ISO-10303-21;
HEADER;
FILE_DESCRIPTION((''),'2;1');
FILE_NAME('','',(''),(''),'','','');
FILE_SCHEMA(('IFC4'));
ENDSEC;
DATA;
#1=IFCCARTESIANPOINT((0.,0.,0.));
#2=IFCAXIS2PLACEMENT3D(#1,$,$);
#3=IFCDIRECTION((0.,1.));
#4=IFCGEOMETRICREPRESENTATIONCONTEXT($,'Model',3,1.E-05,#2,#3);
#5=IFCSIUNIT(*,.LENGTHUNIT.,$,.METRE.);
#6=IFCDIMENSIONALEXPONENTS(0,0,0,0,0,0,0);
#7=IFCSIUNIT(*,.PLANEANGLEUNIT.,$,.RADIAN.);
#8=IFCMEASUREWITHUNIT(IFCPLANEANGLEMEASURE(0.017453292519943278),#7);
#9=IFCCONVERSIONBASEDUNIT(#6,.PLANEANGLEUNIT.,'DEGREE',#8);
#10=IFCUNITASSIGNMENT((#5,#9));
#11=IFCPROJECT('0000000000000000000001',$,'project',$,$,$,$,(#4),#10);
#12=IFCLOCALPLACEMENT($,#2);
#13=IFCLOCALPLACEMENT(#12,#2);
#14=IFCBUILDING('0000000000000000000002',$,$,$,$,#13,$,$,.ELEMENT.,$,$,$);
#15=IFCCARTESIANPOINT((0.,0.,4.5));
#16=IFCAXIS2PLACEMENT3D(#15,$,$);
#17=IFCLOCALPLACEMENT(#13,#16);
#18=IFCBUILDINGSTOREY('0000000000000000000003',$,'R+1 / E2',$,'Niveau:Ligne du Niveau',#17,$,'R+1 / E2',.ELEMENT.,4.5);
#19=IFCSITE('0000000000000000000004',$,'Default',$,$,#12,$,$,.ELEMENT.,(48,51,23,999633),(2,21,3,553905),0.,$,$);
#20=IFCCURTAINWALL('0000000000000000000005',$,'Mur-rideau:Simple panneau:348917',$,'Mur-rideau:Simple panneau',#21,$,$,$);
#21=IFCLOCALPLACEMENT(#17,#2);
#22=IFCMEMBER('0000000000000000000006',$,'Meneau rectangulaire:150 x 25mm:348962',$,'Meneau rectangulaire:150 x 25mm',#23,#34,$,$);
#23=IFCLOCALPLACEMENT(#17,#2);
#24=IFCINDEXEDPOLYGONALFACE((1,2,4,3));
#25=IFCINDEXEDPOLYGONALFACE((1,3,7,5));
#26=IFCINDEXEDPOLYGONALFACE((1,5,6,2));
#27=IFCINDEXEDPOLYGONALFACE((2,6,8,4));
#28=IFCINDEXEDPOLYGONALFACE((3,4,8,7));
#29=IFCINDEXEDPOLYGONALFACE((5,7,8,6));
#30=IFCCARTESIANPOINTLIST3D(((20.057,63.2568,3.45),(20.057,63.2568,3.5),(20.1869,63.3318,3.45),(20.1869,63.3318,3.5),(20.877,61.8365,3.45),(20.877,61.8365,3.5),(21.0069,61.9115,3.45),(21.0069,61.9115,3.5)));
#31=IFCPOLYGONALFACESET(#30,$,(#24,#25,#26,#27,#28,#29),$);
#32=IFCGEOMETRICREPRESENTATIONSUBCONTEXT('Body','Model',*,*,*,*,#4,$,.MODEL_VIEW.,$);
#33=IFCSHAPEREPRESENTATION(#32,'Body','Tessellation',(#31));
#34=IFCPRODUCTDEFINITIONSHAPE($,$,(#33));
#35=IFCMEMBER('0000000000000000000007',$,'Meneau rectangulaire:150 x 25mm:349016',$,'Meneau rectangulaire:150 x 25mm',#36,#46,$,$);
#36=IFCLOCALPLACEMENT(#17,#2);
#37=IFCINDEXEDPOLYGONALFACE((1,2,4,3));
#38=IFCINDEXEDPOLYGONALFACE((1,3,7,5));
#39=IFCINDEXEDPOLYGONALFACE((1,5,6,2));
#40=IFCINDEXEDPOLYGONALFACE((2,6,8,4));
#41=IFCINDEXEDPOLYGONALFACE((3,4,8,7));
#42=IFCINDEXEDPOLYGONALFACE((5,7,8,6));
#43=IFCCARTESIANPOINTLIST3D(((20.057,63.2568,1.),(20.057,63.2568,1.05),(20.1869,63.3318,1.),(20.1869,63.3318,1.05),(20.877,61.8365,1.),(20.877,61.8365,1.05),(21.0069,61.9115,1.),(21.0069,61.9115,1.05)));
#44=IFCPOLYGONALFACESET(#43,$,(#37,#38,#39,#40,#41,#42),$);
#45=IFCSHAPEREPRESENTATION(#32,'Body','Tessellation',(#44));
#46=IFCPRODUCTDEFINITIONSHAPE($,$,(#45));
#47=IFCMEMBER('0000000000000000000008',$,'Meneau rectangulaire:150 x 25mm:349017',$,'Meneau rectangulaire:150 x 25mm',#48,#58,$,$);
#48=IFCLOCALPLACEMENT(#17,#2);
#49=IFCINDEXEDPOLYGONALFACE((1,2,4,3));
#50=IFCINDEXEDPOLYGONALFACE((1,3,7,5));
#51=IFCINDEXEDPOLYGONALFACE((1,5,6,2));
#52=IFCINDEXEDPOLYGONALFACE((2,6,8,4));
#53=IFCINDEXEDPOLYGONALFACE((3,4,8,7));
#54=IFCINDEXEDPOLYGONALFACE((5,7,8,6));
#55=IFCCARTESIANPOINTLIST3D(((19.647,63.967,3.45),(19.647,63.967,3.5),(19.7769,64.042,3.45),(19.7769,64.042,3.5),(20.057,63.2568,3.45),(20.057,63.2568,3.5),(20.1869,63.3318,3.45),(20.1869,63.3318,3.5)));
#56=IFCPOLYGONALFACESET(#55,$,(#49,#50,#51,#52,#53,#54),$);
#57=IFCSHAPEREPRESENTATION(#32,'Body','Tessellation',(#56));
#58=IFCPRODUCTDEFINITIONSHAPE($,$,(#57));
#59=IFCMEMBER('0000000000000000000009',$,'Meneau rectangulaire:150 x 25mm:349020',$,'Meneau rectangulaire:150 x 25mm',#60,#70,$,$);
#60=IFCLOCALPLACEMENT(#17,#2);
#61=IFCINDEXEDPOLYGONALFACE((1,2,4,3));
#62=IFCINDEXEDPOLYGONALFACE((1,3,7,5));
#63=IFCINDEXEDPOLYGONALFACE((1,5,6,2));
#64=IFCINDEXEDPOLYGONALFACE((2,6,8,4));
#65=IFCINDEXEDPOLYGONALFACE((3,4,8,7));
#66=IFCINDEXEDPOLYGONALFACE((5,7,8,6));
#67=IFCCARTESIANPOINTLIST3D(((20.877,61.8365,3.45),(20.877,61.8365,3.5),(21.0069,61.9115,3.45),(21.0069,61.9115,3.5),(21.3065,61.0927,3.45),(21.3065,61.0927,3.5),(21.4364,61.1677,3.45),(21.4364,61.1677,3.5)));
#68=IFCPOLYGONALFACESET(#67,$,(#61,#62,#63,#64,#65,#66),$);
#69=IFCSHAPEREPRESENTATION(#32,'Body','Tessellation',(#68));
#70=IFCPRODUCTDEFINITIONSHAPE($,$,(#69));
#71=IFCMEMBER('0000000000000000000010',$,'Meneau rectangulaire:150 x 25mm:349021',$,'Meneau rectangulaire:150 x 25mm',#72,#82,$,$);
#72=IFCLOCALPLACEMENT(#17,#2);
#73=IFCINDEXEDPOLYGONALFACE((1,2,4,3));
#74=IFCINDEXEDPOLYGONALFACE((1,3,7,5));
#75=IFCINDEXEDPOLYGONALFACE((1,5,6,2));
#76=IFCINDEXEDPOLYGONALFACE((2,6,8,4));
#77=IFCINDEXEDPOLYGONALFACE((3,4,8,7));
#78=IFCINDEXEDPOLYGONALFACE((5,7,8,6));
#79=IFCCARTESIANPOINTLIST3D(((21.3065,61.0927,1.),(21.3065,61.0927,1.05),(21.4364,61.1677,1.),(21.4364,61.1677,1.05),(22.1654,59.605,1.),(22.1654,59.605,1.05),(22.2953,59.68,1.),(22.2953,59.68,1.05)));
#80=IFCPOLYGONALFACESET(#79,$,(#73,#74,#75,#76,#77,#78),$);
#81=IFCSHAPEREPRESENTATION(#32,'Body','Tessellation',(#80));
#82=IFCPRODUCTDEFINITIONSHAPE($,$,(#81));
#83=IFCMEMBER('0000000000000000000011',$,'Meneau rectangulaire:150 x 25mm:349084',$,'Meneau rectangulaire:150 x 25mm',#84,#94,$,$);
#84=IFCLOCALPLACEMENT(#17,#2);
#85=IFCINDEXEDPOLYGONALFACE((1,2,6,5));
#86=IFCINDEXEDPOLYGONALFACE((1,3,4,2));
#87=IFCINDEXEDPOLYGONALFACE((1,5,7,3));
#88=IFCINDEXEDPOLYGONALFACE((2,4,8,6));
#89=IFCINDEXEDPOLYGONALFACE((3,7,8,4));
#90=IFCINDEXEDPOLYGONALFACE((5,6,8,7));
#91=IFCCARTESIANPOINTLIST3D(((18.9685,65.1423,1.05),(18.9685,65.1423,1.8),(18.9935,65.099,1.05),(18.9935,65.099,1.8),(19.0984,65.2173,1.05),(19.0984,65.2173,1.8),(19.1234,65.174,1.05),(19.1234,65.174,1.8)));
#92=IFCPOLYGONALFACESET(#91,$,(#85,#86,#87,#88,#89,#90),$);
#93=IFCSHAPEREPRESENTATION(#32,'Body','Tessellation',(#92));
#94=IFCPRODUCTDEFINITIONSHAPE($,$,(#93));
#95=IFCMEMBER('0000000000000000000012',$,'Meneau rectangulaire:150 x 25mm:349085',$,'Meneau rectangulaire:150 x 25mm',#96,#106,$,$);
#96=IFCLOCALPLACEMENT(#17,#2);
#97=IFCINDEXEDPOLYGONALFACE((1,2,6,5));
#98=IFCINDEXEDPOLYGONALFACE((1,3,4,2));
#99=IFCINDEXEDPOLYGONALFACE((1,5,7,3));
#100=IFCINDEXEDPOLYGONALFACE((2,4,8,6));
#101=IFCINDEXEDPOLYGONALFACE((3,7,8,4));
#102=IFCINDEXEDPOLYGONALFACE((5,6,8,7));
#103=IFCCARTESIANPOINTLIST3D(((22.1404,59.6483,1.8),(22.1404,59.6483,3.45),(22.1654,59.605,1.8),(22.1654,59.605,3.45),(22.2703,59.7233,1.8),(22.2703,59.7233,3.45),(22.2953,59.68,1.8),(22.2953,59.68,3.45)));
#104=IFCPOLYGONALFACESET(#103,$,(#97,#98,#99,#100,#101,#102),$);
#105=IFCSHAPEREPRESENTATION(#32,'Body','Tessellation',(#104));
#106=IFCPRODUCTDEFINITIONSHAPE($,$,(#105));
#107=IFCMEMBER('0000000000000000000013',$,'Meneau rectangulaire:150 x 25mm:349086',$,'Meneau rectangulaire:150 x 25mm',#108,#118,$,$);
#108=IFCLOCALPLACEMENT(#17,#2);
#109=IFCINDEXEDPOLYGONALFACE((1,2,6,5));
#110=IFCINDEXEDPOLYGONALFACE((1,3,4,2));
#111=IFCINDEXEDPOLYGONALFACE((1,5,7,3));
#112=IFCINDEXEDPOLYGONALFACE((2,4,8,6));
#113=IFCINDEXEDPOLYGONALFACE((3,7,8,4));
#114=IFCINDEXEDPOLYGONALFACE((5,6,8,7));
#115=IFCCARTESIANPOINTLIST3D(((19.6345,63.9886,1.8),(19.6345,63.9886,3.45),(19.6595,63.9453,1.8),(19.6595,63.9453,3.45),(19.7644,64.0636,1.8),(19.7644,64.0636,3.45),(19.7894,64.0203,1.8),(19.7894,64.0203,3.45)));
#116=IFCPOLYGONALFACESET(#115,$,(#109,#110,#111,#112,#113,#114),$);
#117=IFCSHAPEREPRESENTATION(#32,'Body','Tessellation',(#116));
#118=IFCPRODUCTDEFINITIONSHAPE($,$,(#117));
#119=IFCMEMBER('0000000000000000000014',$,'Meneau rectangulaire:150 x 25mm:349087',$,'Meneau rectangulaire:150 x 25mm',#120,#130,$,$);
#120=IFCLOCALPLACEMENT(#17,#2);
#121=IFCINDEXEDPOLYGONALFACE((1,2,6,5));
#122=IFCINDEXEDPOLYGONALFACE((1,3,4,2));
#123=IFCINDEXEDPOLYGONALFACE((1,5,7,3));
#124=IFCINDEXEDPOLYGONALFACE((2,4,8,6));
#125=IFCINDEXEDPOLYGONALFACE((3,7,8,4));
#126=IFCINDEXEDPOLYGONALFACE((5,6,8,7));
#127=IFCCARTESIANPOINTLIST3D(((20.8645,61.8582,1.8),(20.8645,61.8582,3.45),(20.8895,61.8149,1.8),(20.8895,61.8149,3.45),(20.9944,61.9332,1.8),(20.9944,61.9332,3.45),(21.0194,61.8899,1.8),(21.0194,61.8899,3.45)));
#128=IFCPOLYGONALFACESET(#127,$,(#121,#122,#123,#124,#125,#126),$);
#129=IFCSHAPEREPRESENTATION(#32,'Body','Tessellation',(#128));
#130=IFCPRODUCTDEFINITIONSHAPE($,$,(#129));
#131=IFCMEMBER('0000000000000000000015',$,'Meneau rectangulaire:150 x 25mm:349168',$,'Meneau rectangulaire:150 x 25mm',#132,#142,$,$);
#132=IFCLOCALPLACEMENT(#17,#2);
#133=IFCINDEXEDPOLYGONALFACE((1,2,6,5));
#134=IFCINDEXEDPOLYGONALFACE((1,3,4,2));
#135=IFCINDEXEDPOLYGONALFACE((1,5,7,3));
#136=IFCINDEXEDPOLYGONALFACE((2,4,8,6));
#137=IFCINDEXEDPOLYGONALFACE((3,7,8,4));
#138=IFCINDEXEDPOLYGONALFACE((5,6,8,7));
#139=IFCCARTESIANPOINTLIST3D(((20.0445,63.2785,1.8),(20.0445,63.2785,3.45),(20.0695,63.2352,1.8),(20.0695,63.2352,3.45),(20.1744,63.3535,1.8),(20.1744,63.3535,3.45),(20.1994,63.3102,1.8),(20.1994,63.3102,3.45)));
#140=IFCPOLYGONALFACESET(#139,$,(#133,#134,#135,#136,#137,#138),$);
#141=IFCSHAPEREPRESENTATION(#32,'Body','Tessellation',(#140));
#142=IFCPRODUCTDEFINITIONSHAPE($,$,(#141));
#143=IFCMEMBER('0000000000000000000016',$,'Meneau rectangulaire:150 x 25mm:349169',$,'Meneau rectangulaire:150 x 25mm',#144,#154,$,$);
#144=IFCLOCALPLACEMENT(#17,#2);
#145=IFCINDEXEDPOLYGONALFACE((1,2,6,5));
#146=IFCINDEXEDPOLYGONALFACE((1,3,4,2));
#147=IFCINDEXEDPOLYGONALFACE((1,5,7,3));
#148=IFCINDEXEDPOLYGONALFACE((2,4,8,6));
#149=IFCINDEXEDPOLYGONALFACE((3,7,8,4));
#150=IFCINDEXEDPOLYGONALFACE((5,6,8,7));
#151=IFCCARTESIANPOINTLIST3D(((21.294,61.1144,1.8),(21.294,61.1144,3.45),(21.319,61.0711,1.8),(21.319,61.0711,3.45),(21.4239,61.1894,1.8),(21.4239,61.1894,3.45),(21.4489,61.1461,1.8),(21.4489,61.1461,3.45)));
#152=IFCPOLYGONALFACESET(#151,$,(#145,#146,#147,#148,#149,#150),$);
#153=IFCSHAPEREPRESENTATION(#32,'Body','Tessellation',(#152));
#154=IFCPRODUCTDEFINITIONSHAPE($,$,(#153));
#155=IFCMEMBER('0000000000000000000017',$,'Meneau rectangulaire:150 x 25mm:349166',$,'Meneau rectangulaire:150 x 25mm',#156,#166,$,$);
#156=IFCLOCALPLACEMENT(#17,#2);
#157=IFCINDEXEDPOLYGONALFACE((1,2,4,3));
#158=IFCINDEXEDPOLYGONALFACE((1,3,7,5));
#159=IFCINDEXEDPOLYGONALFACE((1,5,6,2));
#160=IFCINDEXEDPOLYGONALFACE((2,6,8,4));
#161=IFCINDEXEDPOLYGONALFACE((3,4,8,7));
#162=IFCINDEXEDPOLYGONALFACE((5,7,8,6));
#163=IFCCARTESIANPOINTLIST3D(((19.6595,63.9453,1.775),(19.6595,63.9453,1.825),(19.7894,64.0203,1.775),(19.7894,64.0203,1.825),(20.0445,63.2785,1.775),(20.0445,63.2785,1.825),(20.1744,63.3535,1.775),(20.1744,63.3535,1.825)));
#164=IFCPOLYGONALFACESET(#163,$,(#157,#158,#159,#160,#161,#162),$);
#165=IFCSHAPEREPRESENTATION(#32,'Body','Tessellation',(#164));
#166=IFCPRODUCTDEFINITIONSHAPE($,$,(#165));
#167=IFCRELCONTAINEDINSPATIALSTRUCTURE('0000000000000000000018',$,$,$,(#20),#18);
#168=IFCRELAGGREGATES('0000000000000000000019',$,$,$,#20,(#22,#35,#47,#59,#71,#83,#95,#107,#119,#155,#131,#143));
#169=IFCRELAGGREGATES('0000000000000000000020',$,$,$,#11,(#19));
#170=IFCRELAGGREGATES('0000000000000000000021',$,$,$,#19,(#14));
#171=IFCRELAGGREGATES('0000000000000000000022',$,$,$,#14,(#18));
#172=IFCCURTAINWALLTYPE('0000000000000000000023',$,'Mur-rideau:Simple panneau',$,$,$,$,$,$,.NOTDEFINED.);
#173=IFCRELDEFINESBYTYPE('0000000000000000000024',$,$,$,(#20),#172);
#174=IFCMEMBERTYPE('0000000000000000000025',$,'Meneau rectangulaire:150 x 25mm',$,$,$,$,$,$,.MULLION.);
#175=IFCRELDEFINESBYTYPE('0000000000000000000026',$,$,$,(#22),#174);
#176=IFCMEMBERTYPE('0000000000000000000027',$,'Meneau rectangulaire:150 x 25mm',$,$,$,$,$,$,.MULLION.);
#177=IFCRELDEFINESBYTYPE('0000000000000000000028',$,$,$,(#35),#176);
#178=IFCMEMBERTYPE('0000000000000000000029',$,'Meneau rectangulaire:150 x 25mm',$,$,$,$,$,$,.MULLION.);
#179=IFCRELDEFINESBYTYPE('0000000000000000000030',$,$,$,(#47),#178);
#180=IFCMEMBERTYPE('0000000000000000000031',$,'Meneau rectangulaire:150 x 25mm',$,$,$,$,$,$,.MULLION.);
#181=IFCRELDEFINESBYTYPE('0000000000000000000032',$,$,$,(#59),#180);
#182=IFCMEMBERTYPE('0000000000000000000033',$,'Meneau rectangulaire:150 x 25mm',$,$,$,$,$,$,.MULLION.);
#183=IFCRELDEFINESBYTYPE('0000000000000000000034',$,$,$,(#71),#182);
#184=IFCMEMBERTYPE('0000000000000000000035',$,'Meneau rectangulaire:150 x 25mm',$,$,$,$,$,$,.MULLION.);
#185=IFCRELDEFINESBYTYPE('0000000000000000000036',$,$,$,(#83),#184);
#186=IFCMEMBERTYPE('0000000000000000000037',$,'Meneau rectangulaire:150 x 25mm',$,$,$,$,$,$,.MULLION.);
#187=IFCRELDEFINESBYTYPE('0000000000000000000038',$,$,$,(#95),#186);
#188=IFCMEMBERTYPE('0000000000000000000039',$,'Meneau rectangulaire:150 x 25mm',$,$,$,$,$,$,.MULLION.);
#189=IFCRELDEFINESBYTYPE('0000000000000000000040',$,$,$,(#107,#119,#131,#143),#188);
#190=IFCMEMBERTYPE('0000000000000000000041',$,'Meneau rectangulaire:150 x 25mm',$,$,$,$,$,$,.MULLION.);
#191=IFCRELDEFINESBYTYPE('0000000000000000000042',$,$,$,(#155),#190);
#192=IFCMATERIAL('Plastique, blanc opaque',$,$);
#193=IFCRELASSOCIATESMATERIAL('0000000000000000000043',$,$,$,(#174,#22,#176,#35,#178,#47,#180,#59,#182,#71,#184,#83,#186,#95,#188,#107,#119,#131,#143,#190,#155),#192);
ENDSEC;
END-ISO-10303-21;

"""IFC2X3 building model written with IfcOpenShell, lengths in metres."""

from ifc_helpers import new_model, entity, si_unit, converted_unit, direction, frame, origin, origin_2d_with_axis, place, context, subcontext, project, spatial, rectangle, extrude, source, transform, mapped, material, type_object, type_shapes, element, aggregate, save


model = new_model("IFC2X3")

# Units and contexts
model_context = context("Model", 3, precision=1e-05, world=origin(), true_north=direction((0.0, 1.0)))
body_context = subcontext(model_context, "Body", "Model", "MODEL_VIEW")
ifc_project = project(units=[si_unit("LENGTHUNIT", "METRE"), converted_unit("PLANEANGLEUNIT", "DEGREE", entity("IfcPlaneAngleMeasure", 0.017453292519943278), si_unit("PLANEANGLEUNIT", "RADIAN"), dimensions=[0, 0, 0, 0, 0, 0, 0])], contexts=[model_context])

# Site, building, storey
site_placement = place(None, origin())
site = spatial("IfcSite", under=ifc_project, at=site_placement, Name="Default", CompositionType="ELEMENT", RefLatitude=(48, 51, 23, 999633), RefLongitude=(2, 21, 3, 553905), RefElevation=0.0)
building_placement = place(site_placement, origin())
building = spatial("IfcBuilding", under=site, at=building_placement, CompositionType="ELEMENT")
storey_placement = place(building_placement, frame((0.0, 0.0, 4.5)))
storey = spatial("IfcBuildingStorey", under=building, at=storey_placement, Name="R+1 / E2", ObjectType="Niveau:Ligne du Niveau", LongName="R+1 / E2", CompositionType="ELEMENT", Elevation=4.5)

# Curtain wall, members
curtain_wall_type = type_object("IfcCurtainWallType", Name="Mur-rideau:Simple panneau", PredefinedType="NOTDEFINED")
ifc_material_1 = material(Name="Plastique, blanc opaque")
curtain_wall_1_placement = place(storey_placement, frame((0.0, 0.0, -4.5)))
curtain_wall_1 = element("IfcCurtainWall", 1, at=curtain_wall_1_placement, inside=storey, type_object=curtain_wall_type, Name="Mur-rideau:Simple panneau:348917", ObjectType="Mur-rideau:Simple panneau")
member_type_1 = type_object("IfcMemberType", Name="Meneau rectangulaire:150 x 25mm", PredefinedType="MULLION", material=ifc_material_1)
shared_shape_1 = source(origin(), body_context, "Body", "SweptSolid", [
    extrude(rectangle(XDim=0.05, YDim=0.15, at=origin_2d_with_axis()), frame((-0.025, 0.0, -1.64), z_axis=(0.0, 0.0, 1.0), x_axis=(-1.0, 0.0, 0.0)), (0.0, 0.0, 1.0), 1.64),
])
type_shapes(member_type_1, [shared_shape_1])
member_1_placement = place(curtain_wall_1_placement, frame((20.942, 61.874, 8.0), z_axis=(0.5, -0.866025, 0.0), x_axis=(0.0, 0.0, 1.0)))
member_1 = element("IfcMember", 2, at=member_1_placement, type_object=member_type_1, material=ifc_material_1, Name="Meneau rectangulaire:150 x 25mm:348962", ObjectType="Meneau rectangulaire:150 x 25mm", context=body_context, shape_type="MappedRepresentation", body=[
    mapped(shared_shape_1, transform((0.0, 0.0, 0.0), scale=1.0)),
])
member_type_2 = type_object("IfcMemberType", Name="Meneau rectangulaire:150 x 25mm", PredefinedType="MULLION", material=ifc_material_1)
shared_shape_2 = source(origin(), body_context, "Body", "SweptSolid", [
    extrude(rectangle(XDim=0.05, YDim=0.15, at=origin_2d_with_axis()), frame((-0.025, 0.0, -1.64), z_axis=(0.0, 0.0, 1.0), x_axis=(-1.0, 0.0, 0.0)), (0.0, 0.0, 1.0), 1.64),
])
type_shapes(member_type_2, [shared_shape_2])
member_2_placement = place(curtain_wall_1_placement, frame((20.122, 63.2943, 5.5), z_axis=(-0.5, 0.866025, 0.0), x_axis=(0.0, 0.0, -1.0)))
member_2 = element("IfcMember", 3, at=member_2_placement, type_object=member_type_2, material=ifc_material_1, Name="Meneau rectangulaire:150 x 25mm:349016", ObjectType="Meneau rectangulaire:150 x 25mm", context=body_context, shape_type="MappedRepresentation", body=[
    mapped(shared_shape_2, transform((0.0, 0.0, 0.0), scale=1.0)),
])
member_type_3 = type_object("IfcMemberType", Name="Meneau rectangulaire:150 x 25mm", PredefinedType="MULLION", material=ifc_material_1)
shared_shape_3 = source(origin(), body_context, "Body", "SweptSolid", [
    extrude(rectangle(XDim=0.05, YDim=0.15, at=origin_2d_with_axis()), frame((-0.025, 0.0, -0.82), z_axis=(0.0, 0.0, 1.0), x_axis=(-1.0, 0.0, 0.0)), (0.0, 0.0, 1.0), 0.82),
])
type_shapes(member_type_3, [shared_shape_3])
member_3_placement = place(curtain_wall_1_placement, frame((20.122, 63.2943, 8.0), z_axis=(0.5, -0.866025, 0.0), x_axis=(0.0, 0.0, 1.0)))
member_3 = element("IfcMember", 4, at=member_3_placement, type_object=member_type_3, material=ifc_material_1, Name="Meneau rectangulaire:150 x 25mm:349017", ObjectType="Meneau rectangulaire:150 x 25mm", context=body_context, shape_type="MappedRepresentation", body=[
    mapped(shared_shape_3, transform((0.0, 0.0, 0.0), scale=1.0)),
])
member_type_4 = type_object("IfcMemberType", Name="Meneau rectangulaire:150 x 25mm", PredefinedType="MULLION", material=ifc_material_1)
shared_shape_4 = source(origin(), body_context, "Body", "SweptSolid", [
    extrude(rectangle(XDim=0.05, YDim=0.15, at=origin_2d_with_axis()), frame((-0.025, 0.0, -0.8589), z_axis=(0.0, 0.0, 1.0), x_axis=(-1.0, 0.0, 0.0)), (0.0, 0.0, 1.0), 0.8589),
])
type_shapes(member_type_4, [shared_shape_4])
member_4_placement = place(curtain_wall_1_placement, frame((21.3714, 61.1302, 8.0), z_axis=(0.5, -0.866025, 0.0), x_axis=(0.0, 0.0, 1.0)))
member_4 = element("IfcMember", 5, at=member_4_placement, type_object=member_type_4, material=ifc_material_1, Name="Meneau rectangulaire:150 x 25mm:349020", ObjectType="Meneau rectangulaire:150 x 25mm", context=body_context, shape_type="MappedRepresentation", body=[
    mapped(shared_shape_4, transform((0.0, 0.0, 0.0), scale=1.0)),
])
member_type_5 = type_object("IfcMemberType", Name="Meneau rectangulaire:150 x 25mm", PredefinedType="MULLION", material=ifc_material_1)
shared_shape_5 = source(origin(), body_context, "Body", "SweptSolid", [
    extrude(rectangle(XDim=0.05, YDim=0.15, at=origin_2d_with_axis()), frame((-0.025, 0.0, -1.7178), z_axis=(0.0, 0.0, 1.0), x_axis=(-1.0, 0.0, 0.0)), (0.0, 0.0, 1.0), 1.7178),
])
type_shapes(member_type_5, [shared_shape_5])
member_5_placement = place(curtain_wall_1_placement, frame((21.3714, 61.1302, 5.5), z_axis=(-0.5, 0.866025, 0.0), x_axis=(0.0, 0.0, -1.0)))
member_5 = element("IfcMember", 6, at=member_5_placement, type_object=member_type_5, material=ifc_material_1, Name="Meneau rectangulaire:150 x 25mm:349021", ObjectType="Meneau rectangulaire:150 x 25mm", context=body_context, shape_type="MappedRepresentation", body=[
    mapped(shared_shape_5, transform((0.0, 0.0, 0.0), scale=1.0)),
])
member_type_6 = type_object("IfcMemberType", Name="Meneau rectangulaire:150 x 25mm", PredefinedType="MULLION", material=ifc_material_1)
shared_shape_6 = source(origin(), body_context, "Body", "SweptSolid", [
    extrude(rectangle(XDim=0.05, YDim=0.15, at=origin_2d_with_axis()), frame((-0.025, 0.0, -0.75), z_axis=(0.0, 0.0, 1.0), x_axis=(-1.0, 0.0, 0.0)), (0.0, 0.0, 1.0), 0.75),
])
type_shapes(member_type_6, [shared_shape_6])
member_6_placement = place(curtain_wall_1_placement, frame((19.0334, 65.1798, 6.3), z_axis=(0.0, 0.0, 1.0), x_axis=(-0.5, 0.866025, 0.0)))
member_6 = element("IfcMember", 7, at=member_6_placement, type_object=member_type_6, material=ifc_material_1, Name="Meneau rectangulaire:150 x 25mm:349084", ObjectType="Meneau rectangulaire:150 x 25mm", context=body_context, shape_type="MappedRepresentation", body=[
    mapped(shared_shape_6, transform((0.0, 0.0, 0.0), scale=1.0)),
])
member_type_7 = type_object("IfcMemberType", Name="Meneau rectangulaire:150 x 25mm", PredefinedType="MULLION", material=ifc_material_1)
shared_shape_7 = source(origin(), body_context, "Body", "SweptSolid", [
    extrude(rectangle(XDim=0.05, YDim=0.15, at=origin_2d_with_axis()), frame((-0.025, 0.0, -1.65), z_axis=(0.0, 0.0, 1.0), x_axis=(-1.0, 0.0, 0.0)), (0.0, 0.0, 1.0), 1.65),
])
type_shapes(member_type_7, [shared_shape_7])
member_7_placement = place(curtain_wall_1_placement, frame((22.2304, 59.6425, 6.3), z_axis=(0.0, 0.0, -1.0), x_axis=(0.5, -0.866025, 0.0)))
member_7 = element("IfcMember", 8, at=member_7_placement, type_object=member_type_7, material=ifc_material_1, Name="Meneau rectangulaire:150 x 25mm:349085", ObjectType="Meneau rectangulaire:150 x 25mm", context=body_context, shape_type="MappedRepresentation", body=[
    mapped(shared_shape_7, transform((0.0, 0.0, 0.0), scale=1.0)),
])
member_type_8 = type_object("IfcMemberType", Name="Meneau rectangulaire:150 x 25mm", PredefinedType="MULLION", material=ifc_material_1)
shared_shape_8 = source(origin(), body_context, "Body", "SweptSolid", [
    extrude(rectangle(XDim=0.05, YDim=0.15, at=origin_2d_with_axis()), frame((0.0, 0.0, -1.65), z_axis=(0.0, 0.0, 1.0), x_axis=(-1.0, 0.0, 0.0)), (0.0, 0.0, 1.0), 1.65),
])
type_shapes(member_type_8, [shared_shape_8])
member_8_placement = place(curtain_wall_1_placement, frame((19.712, 64.0045, 6.3), z_axis=(0.0, 0.0, -1.0), x_axis=(0.5, -0.866025, 0.0)))
member_8 = element("IfcMember", 9, at=member_8_placement, type_object=member_type_8, material=ifc_material_1, Name="Meneau rectangulaire:150 x 25mm:349086", ObjectType="Meneau rectangulaire:150 x 25mm", context=body_context, shape_type="MappedRepresentation", body=[
    mapped(shared_shape_8, transform((0.0, 0.0, 0.0), scale=1.0)),
])
member_9_placement = place(curtain_wall_1_placement, frame((20.942, 61.874, 6.3), z_axis=(0.0, 0.0, -1.0), x_axis=(0.5, -0.866025, 0.0)))
member_9 = element("IfcMember", 10, at=member_9_placement, type_object=member_type_8, material=ifc_material_1, Name="Meneau rectangulaire:150 x 25mm:349087", ObjectType="Meneau rectangulaire:150 x 25mm", context=body_context, shape_type="MappedRepresentation", body=[
    mapped(shared_shape_8, transform((0.0, 0.0, 0.0), scale=1.0)),
])
member_10_placement = place(curtain_wall_1_placement, frame((20.122, 63.2943, 6.3), z_axis=(0.0, 0.0, -1.0), x_axis=(0.5, -0.866025, 0.0)))
member_10 = element("IfcMember", 11, at=member_10_placement, type_object=member_type_8, material=ifc_material_1, Name="Meneau rectangulaire:150 x 25mm:349168", ObjectType="Meneau rectangulaire:150 x 25mm", context=body_context, shape_type="MappedRepresentation", body=[
    mapped(shared_shape_8, transform((0.0, 0.0, 0.0), scale=1.0)),
])
member_11_placement = place(curtain_wall_1_placement, frame((21.3714, 61.1302, 6.3), z_axis=(0.0, 0.0, -1.0), x_axis=(0.5, -0.866025, 0.0)))
member_11 = element("IfcMember", 12, at=member_11_placement, type_object=member_type_8, material=ifc_material_1, Name="Meneau rectangulaire:150 x 25mm:349169", ObjectType="Meneau rectangulaire:150 x 25mm", context=body_context, shape_type="MappedRepresentation", body=[
    mapped(shared_shape_8, transform((0.0, 0.0, 0.0), scale=1.0)),
])
member_type_9 = type_object("IfcMemberType", Name="Meneau rectangulaire:150 x 25mm", PredefinedType="MULLION", material=ifc_material_1)
shared_shape_9 = source(origin(), body_context, "Body", "SweptSolid", [
    extrude(rectangle(XDim=0.05, YDim=0.15, at=origin_2d_with_axis()), frame((0.0, 0.0, -0.77), z_axis=(0.0, 0.0, 1.0), x_axis=(-1.0, 0.0, 0.0)), (0.0, 0.0, 1.0), 0.77),
])
type_shapes(member_type_9, [shared_shape_9])
member_12_placement = place(curtain_wall_1_placement, frame((20.1095, 63.316, 6.3), z_axis=(0.5, -0.866025, 0.0), x_axis=(0.0, 0.0, 1.0)))
member_12 = element("IfcMember", 13, at=member_12_placement, type_object=member_type_9, material=ifc_material_1, Name="Meneau rectangulaire:150 x 25mm:349166", ObjectType="Meneau rectangulaire:150 x 25mm", context=body_context, shape_type="MappedRepresentation", body=[
    mapped(shared_shape_9, transform((0.0, 0.0, 0.0), scale=1.0)),
])

aggregate(curtain_wall_1, [member_1, member_2, member_3, member_4, member_5, member_6, member_7, member_8, member_9, member_12, member_10, member_11])

save(model, "model.ifc")
